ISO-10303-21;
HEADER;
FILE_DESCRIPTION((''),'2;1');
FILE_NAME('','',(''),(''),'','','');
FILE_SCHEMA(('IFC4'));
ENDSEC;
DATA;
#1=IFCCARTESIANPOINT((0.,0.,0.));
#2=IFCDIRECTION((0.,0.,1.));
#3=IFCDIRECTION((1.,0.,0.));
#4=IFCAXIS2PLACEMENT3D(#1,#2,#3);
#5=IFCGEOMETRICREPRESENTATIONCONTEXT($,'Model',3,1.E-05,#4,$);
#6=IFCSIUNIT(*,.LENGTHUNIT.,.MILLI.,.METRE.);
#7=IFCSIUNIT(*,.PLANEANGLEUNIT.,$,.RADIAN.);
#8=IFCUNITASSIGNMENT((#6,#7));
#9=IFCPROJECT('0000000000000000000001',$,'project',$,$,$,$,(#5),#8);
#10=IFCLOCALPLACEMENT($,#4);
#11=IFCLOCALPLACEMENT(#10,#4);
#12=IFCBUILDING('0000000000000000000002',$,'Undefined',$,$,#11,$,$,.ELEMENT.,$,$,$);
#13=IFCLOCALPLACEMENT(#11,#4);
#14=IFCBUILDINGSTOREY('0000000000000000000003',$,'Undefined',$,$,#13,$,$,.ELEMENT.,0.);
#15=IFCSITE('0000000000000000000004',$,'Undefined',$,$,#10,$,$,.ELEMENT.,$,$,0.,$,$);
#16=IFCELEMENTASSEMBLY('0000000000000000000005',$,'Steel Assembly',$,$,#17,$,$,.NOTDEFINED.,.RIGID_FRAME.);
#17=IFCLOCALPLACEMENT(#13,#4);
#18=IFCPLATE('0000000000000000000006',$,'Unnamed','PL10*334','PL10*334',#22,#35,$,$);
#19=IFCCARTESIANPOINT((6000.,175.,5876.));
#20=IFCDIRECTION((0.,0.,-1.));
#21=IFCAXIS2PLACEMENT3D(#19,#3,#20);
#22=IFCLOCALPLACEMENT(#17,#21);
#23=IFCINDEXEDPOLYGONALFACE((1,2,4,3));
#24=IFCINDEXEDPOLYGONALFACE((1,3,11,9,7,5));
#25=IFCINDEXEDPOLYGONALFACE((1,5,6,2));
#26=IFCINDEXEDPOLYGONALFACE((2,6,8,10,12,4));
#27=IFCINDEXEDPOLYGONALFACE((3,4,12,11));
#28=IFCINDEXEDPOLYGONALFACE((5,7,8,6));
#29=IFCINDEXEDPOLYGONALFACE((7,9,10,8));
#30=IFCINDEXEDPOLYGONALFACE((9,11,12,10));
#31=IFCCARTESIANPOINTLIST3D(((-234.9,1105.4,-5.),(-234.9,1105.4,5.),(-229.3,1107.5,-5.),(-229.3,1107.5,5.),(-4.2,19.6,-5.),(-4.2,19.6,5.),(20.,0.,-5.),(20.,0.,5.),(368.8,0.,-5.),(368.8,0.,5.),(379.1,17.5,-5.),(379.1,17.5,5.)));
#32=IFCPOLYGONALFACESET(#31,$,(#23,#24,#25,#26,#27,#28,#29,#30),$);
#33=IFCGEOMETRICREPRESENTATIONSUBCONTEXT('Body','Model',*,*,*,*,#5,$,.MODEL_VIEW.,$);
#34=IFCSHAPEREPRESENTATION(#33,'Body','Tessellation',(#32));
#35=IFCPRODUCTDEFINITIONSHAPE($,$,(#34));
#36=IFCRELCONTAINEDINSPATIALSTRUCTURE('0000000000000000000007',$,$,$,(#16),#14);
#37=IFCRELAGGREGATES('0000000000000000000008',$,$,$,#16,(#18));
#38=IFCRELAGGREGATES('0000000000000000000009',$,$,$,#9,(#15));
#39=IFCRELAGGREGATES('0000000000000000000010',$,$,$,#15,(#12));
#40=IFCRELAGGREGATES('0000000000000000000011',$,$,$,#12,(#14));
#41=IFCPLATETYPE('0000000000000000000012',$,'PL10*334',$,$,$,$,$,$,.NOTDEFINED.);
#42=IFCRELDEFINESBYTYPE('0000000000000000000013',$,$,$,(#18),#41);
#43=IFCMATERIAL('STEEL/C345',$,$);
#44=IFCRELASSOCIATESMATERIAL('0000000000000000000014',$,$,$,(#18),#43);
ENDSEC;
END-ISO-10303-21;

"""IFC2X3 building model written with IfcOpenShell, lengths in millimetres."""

from ifc_helpers import new_model, si_unit, frame, origin_with_axes, place, context, subcontext, project, spatial, polyline, outline, extrude, material, type_object, element, aggregate, save


model = new_model("IFC2X3")

# Units and contexts
model_context = context("Model", 3, precision=1e-05, world=origin_with_axes())
body_context = subcontext(model_context, "Body", "Model", "MODEL_VIEW")
ifc_project = project(units=[si_unit("LENGTHUNIT", "METRE", prefix="MILLI"), si_unit("PLANEANGLEUNIT", "RADIAN")], contexts=[model_context])

# Site, building, storey
site_placement = place(None, origin_with_axes())
site = spatial("IfcSite", under=ifc_project, at=site_placement, Name="Undefined", CompositionType="ELEMENT", RefElevation=0.0)
building_placement = place(site_placement, origin_with_axes())
building = spatial("IfcBuilding", under=site, at=building_placement, Name="Undefined", CompositionType="ELEMENT")
storey_placement = place(building_placement, origin_with_axes())
storey = spatial("IfcBuildingStorey", under=building, at=storey_placement, Name="Undefined", CompositionType="ELEMENT", Elevation=0.0)

# Shared definitions
ifc_material_1 = material(Name="STEEL/C345")

# Element assembly, plate
assembly_1_placement = place(storey_placement, origin_with_axes())
assembly_1 = element("IfcElementAssembly", 1, at=assembly_1_placement, inside=storey, Name="Steel Assembly", AssemblyPlace="NOTDEFINED", PredefinedType="RIGID_FRAME")
plate_type_1 = type_object("IfcPlateType", Name="PL10*334", PredefinedType="NOTDEFINED")
plate_1_placement = place(assembly_1_placement, frame((6000.0, 175.0, 5876.0), z_axis=(1.0, 0.0, 0.0), x_axis=(0.0, 0.0, -1.0)))
plate_1 = element("IfcPlate", 2, at=plate_1_placement, type_object=plate_type_1, material=ifc_material_1, Name="Unnamed", Description="PL10*334", ObjectType="PL10*334", context=body_context, shape_type="SweptSolid", body=[
    extrude(outline(polyline([(-4.2, 19.6), (20.0, 0.0), (368.8, 0.0), (379.1, 17.5), (-229.3, 1107.5), (-234.9, 1105.4), (-4.2, 19.6)])), frame((0.0, 0.0, -5.0), z_axis=(0.0, 0.0, 1.0), x_axis=(1.0, 0.0, 0.0)), (0.0, 0.0, 1.0), 10.0),
])
aggregate(assembly_1, [plate_1])

save(model, "model.ifc")
